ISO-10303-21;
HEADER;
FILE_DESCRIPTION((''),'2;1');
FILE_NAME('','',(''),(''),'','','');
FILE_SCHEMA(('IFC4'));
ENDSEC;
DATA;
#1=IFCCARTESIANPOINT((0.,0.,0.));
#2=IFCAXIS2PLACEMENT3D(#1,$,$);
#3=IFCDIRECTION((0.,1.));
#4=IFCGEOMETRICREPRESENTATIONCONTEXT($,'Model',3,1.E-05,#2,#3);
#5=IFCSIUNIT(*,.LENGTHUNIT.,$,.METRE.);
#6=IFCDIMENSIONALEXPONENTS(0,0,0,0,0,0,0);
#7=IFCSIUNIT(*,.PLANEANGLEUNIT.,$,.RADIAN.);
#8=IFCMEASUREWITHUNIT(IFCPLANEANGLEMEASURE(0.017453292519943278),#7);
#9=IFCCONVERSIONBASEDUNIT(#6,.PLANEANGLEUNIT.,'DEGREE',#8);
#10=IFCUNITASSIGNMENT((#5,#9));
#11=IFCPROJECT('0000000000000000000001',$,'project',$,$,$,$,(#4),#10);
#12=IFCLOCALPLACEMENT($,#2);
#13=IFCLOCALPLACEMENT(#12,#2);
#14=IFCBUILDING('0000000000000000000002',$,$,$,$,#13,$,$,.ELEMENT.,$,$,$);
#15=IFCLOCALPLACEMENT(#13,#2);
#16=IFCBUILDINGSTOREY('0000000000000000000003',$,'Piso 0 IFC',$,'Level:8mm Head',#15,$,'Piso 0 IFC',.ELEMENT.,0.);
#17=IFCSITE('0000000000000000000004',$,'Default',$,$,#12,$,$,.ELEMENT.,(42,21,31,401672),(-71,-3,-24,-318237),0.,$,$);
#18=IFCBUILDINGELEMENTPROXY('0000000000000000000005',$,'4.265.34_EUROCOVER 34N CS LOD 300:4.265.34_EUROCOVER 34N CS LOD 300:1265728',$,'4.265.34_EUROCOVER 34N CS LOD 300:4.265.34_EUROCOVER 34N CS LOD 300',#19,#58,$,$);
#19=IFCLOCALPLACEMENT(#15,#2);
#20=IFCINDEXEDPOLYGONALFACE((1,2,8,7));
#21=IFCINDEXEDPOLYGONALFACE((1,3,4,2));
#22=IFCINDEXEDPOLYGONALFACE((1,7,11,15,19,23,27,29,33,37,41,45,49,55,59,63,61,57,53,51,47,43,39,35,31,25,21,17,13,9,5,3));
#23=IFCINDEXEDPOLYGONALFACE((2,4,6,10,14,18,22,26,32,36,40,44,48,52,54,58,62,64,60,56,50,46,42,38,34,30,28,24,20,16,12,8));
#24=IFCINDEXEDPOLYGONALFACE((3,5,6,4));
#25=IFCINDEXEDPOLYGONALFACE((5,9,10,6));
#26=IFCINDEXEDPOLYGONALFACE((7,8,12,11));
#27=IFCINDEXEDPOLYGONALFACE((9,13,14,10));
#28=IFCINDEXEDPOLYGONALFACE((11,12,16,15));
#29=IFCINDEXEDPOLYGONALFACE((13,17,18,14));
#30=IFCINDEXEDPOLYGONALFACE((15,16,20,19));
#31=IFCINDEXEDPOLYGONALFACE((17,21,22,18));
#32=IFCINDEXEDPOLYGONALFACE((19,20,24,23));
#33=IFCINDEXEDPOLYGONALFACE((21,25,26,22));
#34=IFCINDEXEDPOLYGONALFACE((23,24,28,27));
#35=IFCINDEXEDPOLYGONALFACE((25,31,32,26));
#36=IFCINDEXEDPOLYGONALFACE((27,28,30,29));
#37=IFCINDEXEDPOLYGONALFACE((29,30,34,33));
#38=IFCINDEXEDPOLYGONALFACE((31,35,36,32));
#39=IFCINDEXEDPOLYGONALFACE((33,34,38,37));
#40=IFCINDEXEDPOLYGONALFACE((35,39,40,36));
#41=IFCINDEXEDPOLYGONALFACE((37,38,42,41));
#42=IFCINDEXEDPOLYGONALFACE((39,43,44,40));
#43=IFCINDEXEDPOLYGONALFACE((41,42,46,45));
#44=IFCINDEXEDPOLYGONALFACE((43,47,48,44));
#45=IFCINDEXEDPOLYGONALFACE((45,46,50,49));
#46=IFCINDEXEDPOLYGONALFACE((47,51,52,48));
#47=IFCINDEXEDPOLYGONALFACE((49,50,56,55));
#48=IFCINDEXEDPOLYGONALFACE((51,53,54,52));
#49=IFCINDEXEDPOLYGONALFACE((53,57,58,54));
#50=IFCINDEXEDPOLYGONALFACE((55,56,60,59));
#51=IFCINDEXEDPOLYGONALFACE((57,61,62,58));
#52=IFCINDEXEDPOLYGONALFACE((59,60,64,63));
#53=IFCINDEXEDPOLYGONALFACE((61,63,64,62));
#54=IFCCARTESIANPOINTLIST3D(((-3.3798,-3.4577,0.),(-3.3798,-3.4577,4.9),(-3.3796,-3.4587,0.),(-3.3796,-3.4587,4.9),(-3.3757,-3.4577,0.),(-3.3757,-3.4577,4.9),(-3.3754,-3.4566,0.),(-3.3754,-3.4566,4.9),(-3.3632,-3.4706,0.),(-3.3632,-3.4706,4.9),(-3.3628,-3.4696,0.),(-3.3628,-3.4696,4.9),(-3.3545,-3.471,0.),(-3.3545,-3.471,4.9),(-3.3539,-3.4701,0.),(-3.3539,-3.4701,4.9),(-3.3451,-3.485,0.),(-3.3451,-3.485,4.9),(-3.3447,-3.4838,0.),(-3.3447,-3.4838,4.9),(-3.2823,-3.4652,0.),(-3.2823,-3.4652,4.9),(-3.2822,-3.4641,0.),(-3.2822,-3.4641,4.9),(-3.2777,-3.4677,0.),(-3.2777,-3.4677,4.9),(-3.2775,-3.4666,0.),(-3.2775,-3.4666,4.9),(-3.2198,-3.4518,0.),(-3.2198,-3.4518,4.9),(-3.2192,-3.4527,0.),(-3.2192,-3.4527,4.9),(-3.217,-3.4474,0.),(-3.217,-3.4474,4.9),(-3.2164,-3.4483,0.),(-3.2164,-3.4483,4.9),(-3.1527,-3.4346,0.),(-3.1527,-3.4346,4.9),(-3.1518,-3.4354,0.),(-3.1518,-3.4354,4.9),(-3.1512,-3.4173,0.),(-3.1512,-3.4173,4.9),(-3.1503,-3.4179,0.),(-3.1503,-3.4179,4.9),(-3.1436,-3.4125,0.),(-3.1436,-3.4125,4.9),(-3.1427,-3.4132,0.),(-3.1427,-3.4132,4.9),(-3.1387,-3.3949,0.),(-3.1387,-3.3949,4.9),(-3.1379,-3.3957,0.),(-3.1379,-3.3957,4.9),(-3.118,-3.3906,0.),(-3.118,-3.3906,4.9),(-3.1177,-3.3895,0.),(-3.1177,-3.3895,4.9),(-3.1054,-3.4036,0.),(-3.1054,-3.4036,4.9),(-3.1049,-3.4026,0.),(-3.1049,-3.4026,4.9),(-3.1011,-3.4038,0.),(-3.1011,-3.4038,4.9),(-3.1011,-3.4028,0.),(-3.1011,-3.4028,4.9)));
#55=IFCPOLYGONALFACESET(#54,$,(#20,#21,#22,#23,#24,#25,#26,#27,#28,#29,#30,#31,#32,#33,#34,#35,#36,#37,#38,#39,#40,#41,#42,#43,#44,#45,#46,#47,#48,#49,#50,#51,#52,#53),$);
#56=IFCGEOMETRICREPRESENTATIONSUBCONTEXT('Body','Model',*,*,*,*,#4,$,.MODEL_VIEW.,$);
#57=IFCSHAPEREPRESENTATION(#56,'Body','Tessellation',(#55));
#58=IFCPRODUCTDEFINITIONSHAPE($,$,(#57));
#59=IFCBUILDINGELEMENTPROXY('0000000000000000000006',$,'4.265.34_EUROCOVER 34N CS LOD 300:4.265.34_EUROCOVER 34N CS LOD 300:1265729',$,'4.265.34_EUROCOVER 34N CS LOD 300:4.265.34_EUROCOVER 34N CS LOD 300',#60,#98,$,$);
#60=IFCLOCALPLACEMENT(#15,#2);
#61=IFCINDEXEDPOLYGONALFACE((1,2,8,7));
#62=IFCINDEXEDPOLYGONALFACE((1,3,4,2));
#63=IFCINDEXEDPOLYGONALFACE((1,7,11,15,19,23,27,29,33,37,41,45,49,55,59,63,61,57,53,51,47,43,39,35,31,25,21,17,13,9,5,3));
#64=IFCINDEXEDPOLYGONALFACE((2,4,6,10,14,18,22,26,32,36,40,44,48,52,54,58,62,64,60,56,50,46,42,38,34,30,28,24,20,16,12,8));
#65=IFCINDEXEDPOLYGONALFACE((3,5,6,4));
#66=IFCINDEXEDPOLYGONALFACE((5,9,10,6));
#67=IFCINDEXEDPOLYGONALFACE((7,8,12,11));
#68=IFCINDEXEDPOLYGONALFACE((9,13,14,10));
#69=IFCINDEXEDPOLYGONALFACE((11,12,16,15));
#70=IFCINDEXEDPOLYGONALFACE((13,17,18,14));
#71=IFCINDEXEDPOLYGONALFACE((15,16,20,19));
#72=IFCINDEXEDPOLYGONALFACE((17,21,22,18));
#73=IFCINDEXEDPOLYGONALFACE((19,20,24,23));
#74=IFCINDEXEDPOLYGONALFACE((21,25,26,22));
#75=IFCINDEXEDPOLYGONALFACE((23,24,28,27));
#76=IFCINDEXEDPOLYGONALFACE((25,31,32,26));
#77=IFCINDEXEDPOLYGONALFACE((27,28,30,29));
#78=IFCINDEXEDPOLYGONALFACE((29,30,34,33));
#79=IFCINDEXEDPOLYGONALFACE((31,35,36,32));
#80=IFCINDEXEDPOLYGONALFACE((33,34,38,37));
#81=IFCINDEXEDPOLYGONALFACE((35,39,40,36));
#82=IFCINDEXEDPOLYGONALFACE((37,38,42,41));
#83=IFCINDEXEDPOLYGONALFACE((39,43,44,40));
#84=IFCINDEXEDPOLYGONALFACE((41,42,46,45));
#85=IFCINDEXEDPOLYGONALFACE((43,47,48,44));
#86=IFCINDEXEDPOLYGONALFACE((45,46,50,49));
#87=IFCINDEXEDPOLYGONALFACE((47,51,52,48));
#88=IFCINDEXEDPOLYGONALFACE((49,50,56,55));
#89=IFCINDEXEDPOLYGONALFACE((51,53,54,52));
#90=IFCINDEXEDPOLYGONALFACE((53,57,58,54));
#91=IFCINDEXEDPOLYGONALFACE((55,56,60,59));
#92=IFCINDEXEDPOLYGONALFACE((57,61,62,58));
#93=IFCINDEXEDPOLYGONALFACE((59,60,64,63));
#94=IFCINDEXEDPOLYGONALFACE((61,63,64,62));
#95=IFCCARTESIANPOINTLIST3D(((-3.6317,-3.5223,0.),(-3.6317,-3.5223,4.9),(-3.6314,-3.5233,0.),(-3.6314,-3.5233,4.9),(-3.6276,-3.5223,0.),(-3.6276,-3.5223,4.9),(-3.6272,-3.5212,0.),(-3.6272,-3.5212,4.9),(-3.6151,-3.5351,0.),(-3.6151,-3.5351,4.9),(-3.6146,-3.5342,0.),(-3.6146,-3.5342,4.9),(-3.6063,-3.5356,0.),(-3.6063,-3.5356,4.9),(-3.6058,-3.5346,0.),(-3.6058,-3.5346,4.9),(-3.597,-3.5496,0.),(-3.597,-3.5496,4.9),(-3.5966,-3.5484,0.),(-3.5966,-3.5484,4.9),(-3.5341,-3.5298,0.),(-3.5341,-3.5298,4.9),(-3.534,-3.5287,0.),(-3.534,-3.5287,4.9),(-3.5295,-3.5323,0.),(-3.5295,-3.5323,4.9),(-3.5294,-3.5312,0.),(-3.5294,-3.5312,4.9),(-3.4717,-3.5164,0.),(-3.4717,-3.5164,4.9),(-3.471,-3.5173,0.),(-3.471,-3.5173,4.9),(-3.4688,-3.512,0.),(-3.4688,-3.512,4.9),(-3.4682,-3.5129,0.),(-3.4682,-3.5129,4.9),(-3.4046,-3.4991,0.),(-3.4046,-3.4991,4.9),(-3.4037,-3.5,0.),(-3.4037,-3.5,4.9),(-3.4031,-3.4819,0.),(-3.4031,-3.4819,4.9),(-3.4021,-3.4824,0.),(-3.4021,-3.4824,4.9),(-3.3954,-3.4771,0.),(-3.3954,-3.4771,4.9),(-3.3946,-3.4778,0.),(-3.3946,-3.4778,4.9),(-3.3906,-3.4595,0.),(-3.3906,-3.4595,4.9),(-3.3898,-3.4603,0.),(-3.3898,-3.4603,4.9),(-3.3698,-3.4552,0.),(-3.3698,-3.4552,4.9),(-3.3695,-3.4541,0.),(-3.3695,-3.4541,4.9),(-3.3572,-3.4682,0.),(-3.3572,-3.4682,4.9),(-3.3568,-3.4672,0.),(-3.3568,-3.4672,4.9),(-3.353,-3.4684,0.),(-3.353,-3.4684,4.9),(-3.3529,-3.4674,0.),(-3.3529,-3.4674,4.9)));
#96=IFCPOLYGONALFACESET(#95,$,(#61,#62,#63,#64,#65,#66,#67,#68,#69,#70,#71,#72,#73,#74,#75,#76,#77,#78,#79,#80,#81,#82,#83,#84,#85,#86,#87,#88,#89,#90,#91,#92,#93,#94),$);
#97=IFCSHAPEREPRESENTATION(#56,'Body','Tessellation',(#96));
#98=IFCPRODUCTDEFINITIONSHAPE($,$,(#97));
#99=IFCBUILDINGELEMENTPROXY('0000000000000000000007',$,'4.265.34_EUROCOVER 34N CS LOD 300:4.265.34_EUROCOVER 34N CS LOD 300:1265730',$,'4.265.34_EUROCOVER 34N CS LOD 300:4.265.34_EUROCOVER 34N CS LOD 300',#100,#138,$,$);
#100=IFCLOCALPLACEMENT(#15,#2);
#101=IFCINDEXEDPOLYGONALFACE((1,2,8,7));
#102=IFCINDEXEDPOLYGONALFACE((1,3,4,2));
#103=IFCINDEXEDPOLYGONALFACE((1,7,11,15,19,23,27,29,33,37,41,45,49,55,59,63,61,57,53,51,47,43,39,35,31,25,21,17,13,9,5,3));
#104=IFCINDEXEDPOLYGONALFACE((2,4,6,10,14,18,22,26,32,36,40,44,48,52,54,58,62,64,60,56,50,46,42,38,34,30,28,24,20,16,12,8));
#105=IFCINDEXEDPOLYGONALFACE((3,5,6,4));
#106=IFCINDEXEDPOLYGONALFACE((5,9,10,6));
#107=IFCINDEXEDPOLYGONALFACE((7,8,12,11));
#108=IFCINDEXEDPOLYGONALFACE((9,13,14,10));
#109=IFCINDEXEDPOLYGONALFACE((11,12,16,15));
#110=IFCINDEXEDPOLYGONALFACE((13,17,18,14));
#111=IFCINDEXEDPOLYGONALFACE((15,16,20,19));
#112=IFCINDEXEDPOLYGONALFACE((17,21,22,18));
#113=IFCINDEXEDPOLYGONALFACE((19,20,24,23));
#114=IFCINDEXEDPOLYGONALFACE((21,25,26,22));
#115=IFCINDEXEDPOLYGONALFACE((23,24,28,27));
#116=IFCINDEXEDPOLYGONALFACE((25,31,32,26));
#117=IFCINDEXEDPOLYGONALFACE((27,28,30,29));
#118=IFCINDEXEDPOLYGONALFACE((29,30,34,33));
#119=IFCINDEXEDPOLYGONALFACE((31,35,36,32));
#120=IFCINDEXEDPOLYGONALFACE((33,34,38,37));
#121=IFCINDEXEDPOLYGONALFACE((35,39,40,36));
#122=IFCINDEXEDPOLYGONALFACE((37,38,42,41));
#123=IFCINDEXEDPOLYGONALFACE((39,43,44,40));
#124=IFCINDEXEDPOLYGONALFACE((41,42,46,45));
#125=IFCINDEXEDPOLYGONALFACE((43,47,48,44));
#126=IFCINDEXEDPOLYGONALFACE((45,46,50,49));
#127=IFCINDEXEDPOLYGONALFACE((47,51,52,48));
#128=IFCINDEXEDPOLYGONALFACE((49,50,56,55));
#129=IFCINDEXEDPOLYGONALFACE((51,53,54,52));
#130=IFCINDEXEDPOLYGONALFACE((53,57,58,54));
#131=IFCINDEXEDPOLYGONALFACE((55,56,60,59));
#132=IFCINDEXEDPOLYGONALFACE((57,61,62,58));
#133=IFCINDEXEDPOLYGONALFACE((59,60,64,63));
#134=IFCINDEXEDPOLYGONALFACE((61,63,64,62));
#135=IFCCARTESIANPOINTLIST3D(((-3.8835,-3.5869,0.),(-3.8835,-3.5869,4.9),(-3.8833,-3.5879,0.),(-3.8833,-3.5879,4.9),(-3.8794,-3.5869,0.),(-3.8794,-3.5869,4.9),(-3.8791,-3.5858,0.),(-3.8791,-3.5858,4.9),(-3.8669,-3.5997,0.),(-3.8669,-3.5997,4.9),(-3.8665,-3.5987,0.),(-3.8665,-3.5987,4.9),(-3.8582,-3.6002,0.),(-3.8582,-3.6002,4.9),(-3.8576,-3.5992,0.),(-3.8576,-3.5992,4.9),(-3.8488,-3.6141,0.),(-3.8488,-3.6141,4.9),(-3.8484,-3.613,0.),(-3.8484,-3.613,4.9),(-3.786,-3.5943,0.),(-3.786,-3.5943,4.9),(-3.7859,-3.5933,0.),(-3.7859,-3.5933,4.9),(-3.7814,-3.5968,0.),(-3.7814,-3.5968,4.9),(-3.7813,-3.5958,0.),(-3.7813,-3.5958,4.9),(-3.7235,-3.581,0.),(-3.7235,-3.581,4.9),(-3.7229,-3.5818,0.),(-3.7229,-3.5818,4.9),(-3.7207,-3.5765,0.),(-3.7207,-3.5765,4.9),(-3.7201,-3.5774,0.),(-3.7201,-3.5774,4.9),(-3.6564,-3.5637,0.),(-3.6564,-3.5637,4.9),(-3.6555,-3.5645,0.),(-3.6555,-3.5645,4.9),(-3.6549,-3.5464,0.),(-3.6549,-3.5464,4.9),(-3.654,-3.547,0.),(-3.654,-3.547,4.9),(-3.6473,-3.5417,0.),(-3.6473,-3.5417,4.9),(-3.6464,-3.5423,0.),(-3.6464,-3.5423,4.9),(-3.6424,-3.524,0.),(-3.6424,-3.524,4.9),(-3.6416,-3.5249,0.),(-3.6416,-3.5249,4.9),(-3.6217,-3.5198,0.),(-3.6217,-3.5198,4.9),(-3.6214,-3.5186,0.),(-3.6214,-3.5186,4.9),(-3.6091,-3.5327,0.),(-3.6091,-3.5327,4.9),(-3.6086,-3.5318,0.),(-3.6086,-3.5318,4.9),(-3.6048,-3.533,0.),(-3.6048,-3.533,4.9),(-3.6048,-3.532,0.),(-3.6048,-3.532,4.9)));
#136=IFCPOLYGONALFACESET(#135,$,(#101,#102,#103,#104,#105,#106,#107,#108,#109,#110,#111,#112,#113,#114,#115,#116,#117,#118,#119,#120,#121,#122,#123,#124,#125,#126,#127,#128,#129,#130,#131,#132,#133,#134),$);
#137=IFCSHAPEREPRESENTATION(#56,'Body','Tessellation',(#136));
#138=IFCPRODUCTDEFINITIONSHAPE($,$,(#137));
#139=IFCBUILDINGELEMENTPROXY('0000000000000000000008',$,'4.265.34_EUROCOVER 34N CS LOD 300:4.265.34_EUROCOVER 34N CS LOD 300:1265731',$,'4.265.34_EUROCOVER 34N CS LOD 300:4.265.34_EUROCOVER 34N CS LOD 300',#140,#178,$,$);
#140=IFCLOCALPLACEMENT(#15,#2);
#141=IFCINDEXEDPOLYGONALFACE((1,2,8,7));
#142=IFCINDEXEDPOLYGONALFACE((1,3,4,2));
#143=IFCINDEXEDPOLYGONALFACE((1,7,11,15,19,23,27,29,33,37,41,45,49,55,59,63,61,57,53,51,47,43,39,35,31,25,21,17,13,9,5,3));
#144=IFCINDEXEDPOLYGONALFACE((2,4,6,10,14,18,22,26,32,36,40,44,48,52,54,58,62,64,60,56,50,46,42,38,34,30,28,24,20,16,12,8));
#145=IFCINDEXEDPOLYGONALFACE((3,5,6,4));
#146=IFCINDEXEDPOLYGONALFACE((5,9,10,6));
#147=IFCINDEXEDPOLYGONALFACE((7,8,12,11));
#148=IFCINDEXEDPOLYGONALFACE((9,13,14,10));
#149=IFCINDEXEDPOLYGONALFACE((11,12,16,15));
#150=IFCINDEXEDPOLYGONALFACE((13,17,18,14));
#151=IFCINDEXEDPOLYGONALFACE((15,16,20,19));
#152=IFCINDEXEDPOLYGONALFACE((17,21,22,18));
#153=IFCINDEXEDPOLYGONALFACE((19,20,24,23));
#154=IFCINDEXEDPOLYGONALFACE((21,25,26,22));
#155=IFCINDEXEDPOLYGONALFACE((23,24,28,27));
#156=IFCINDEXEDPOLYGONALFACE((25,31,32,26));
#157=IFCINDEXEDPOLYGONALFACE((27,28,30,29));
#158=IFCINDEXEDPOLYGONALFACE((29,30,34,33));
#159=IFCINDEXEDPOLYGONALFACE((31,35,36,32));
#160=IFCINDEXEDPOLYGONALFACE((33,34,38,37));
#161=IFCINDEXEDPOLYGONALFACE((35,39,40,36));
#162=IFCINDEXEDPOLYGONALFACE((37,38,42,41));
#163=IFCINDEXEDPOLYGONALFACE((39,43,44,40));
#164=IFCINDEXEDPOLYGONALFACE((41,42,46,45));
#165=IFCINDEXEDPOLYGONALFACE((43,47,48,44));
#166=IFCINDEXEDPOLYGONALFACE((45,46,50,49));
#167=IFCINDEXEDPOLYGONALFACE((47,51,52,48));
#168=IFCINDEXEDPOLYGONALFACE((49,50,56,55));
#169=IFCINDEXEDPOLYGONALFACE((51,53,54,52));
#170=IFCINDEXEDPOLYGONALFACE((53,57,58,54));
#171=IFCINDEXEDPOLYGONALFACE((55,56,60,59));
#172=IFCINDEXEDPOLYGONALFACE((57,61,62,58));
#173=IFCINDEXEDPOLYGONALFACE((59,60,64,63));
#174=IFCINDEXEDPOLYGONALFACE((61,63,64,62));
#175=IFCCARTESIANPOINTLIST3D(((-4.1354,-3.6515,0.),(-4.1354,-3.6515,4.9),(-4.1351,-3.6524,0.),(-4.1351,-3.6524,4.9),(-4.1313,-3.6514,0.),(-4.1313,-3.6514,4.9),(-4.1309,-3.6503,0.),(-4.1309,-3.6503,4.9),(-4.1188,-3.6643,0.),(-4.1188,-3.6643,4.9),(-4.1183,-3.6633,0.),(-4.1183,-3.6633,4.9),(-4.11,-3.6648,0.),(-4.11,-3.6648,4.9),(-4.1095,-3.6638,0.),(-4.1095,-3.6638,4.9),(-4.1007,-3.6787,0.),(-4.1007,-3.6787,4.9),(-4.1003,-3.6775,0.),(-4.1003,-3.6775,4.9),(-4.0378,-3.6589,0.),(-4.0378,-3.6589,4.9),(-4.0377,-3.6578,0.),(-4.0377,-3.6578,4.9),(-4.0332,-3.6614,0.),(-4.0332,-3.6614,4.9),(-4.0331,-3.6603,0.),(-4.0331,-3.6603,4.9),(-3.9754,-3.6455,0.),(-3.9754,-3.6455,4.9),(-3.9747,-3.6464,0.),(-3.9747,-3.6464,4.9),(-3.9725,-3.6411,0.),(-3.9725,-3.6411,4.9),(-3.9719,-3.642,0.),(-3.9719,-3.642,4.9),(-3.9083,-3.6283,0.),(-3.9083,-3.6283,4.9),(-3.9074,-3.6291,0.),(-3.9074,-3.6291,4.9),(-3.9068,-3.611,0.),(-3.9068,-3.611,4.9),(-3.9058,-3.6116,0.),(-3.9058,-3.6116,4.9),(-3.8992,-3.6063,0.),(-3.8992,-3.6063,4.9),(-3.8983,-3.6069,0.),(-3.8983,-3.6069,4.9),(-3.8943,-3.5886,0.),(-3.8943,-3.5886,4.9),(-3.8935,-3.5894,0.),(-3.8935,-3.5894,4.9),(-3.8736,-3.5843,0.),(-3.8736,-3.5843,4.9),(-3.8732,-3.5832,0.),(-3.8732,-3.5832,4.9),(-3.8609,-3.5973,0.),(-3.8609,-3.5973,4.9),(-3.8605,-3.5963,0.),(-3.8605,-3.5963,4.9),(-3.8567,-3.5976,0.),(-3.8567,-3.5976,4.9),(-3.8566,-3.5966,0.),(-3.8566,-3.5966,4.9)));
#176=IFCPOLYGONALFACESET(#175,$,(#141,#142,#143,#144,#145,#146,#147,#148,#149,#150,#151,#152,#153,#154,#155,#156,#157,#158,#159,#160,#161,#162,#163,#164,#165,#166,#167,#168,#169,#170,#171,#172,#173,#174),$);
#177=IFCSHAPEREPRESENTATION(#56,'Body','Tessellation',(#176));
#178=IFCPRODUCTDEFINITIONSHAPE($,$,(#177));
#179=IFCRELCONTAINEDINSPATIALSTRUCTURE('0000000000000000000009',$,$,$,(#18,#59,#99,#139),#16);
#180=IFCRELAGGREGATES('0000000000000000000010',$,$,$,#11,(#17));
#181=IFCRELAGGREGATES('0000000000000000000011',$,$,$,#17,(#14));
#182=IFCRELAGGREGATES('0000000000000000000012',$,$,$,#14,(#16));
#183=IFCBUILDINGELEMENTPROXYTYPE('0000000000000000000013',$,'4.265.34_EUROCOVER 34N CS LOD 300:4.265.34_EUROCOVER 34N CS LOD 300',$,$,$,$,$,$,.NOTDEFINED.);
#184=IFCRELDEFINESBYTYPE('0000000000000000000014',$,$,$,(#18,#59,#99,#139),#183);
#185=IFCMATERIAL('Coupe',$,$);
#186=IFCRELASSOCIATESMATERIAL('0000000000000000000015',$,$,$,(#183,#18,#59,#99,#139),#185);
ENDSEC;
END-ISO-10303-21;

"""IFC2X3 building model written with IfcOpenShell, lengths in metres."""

from ifc_helpers import new_model, entity, si_unit, converted_unit, direction, frame, origin, place, context, subcontext, project, spatial, polyline, outline, extrude, source, transform, mapped, material, type_object, type_shapes, element, save


model = new_model("IFC2X3")

# Units and contexts
model_context = context("Model", 3, precision=1e-05, world=origin(), true_north=direction((0.0, 1.0)))
body_context = subcontext(model_context, "Body", "Model", "MODEL_VIEW")
ifc_project = project(units=[si_unit("LENGTHUNIT", "METRE"), converted_unit("PLANEANGLEUNIT", "DEGREE", entity("IfcPlaneAngleMeasure", 0.017453292519943278), si_unit("PLANEANGLEUNIT", "RADIAN"), dimensions=[0, 0, 0, 0, 0, 0, 0])], contexts=[model_context])

# Site, building, storey
site_placement = place(None, origin())
site = spatial("IfcSite", under=ifc_project, at=site_placement, Name="Default", CompositionType="ELEMENT", RefLatitude=(42, 21, 31, 401672), RefLongitude=(-71, -3, -24, -318237), RefElevation=0.0)
building_placement = place(site_placement, origin())
building = spatial("IfcBuilding", under=site, at=building_placement, CompositionType="ELEMENT")
storey_placement = place(building_placement, origin())
storey = spatial("IfcBuildingStorey", under=building, at=storey_placement, Name="Piso 0 IFC", ObjectType="Level:8mm Head", LongName="Piso 0 IFC", CompositionType="ELEMENT", Elevation=0.0)

# Building element proxies
ifc_material_1 = material(Name="Coupe")
building_element_proxy_type = type_object("IfcBuildingElementProxyType", Name="4.265.34_EUROCOVER 34N CS LOD 300:4.265.34_EUROCOVER 34N CS LOD 300", PredefinedType="NOTDEFINED", material=ifc_material_1)
shared_shape_1 = source(origin(), body_context, "Body", "SweptSolid", [
    extrude(outline(polyline([(0.0449, 0.1162), (0.063, 0.1162), (0.0661, 0.1191), (0.0654, 0.1198), (0.0626, 0.1172), (0.0443, 0.1172), (0.0335, 0.0983), (0.0428, 0.0826), (0.0409, 0.0738), (0.0522, 0.0606), (0.0167, 0.0056), (0.0179, 0.0005), (-0.0117, -0.0512), (-0.0167, -0.0528), (-0.0462, -0.1114), (-0.0624, -0.1084), (-0.069, -0.1145), (-0.0871, -0.1145), (-0.0893, -0.1184), (-0.0885, -0.1189), (-0.0865, -0.1155), (-0.0686, -0.1155), (-0.0621, -0.1095), (-0.0456, -0.1125), (-0.016, -0.0536), (-0.0111, -0.0521), (0.0189, 0.0004), (0.0177, 0.0054), (0.0535, 0.0607), (0.0419, 0.074), (0.0438, 0.0827), (0.0347, 0.0983), (0.0449, 0.1162)])), frame((-0.0171, -0.0163, 0.0), z_axis=(0.0, 0.0, 1.0), x_axis=(-0.496574, 0.867994, 0.0)), (0.0, 0.0, 1.0), 4.9),
])
type_shapes(building_element_proxy_type, [shared_shape_1])
for number, where, z_axis, x_axis, name in (
    (1, (-3.2452, -3.4594, 0.0), (0.0, 0.0, 1.0), (-0.968666, -0.248367, 0.0), "4.265.34_EUROCOVER 34N CS LOD 300:4.265.34_EUROCOVER 34N CS LOD 300:1265728"),
    (2, (-3.497, -3.5239, 0.0), (0.0, 0.0, 1.0), (-0.968666, -0.248367, 0.0), "4.265.34_EUROCOVER 34N CS LOD 300:4.265.34_EUROCOVER 34N CS LOD 300:1265729"),
    (3, (-3.7489, -3.5885, 0.0), (0.0, 0.0, 1.0), (-0.968666, -0.248367, 0.0), "4.265.34_EUROCOVER 34N CS LOD 300:4.265.34_EUROCOVER 34N CS LOD 300:1265730"),
    (4, (-4.0007, -3.6531, 0.0), (0.0, 0.0, 1.0), (-0.968666, -0.248367, 0.0), "4.265.34_EUROCOVER 34N CS LOD 300:4.265.34_EUROCOVER 34N CS LOD 300:1265731"),
):
    element("IfcBuildingElementProxy", number, at=place(storey_placement, frame(where, z_axis=z_axis, x_axis=x_axis)), inside=storey, type_object=building_element_proxy_type, material=ifc_material_1, Name=name, ObjectType="4.265.34_EUROCOVER 34N CS LOD 300:4.265.34_EUROCOVER 34N CS LOD 300", context=body_context, shape_type="MappedRepresentation", body=[
        mapped(shared_shape_1, transform((0.0, 0.0, 0.0), scale=1.0)),
    ])

save(model, "model.ifc")
